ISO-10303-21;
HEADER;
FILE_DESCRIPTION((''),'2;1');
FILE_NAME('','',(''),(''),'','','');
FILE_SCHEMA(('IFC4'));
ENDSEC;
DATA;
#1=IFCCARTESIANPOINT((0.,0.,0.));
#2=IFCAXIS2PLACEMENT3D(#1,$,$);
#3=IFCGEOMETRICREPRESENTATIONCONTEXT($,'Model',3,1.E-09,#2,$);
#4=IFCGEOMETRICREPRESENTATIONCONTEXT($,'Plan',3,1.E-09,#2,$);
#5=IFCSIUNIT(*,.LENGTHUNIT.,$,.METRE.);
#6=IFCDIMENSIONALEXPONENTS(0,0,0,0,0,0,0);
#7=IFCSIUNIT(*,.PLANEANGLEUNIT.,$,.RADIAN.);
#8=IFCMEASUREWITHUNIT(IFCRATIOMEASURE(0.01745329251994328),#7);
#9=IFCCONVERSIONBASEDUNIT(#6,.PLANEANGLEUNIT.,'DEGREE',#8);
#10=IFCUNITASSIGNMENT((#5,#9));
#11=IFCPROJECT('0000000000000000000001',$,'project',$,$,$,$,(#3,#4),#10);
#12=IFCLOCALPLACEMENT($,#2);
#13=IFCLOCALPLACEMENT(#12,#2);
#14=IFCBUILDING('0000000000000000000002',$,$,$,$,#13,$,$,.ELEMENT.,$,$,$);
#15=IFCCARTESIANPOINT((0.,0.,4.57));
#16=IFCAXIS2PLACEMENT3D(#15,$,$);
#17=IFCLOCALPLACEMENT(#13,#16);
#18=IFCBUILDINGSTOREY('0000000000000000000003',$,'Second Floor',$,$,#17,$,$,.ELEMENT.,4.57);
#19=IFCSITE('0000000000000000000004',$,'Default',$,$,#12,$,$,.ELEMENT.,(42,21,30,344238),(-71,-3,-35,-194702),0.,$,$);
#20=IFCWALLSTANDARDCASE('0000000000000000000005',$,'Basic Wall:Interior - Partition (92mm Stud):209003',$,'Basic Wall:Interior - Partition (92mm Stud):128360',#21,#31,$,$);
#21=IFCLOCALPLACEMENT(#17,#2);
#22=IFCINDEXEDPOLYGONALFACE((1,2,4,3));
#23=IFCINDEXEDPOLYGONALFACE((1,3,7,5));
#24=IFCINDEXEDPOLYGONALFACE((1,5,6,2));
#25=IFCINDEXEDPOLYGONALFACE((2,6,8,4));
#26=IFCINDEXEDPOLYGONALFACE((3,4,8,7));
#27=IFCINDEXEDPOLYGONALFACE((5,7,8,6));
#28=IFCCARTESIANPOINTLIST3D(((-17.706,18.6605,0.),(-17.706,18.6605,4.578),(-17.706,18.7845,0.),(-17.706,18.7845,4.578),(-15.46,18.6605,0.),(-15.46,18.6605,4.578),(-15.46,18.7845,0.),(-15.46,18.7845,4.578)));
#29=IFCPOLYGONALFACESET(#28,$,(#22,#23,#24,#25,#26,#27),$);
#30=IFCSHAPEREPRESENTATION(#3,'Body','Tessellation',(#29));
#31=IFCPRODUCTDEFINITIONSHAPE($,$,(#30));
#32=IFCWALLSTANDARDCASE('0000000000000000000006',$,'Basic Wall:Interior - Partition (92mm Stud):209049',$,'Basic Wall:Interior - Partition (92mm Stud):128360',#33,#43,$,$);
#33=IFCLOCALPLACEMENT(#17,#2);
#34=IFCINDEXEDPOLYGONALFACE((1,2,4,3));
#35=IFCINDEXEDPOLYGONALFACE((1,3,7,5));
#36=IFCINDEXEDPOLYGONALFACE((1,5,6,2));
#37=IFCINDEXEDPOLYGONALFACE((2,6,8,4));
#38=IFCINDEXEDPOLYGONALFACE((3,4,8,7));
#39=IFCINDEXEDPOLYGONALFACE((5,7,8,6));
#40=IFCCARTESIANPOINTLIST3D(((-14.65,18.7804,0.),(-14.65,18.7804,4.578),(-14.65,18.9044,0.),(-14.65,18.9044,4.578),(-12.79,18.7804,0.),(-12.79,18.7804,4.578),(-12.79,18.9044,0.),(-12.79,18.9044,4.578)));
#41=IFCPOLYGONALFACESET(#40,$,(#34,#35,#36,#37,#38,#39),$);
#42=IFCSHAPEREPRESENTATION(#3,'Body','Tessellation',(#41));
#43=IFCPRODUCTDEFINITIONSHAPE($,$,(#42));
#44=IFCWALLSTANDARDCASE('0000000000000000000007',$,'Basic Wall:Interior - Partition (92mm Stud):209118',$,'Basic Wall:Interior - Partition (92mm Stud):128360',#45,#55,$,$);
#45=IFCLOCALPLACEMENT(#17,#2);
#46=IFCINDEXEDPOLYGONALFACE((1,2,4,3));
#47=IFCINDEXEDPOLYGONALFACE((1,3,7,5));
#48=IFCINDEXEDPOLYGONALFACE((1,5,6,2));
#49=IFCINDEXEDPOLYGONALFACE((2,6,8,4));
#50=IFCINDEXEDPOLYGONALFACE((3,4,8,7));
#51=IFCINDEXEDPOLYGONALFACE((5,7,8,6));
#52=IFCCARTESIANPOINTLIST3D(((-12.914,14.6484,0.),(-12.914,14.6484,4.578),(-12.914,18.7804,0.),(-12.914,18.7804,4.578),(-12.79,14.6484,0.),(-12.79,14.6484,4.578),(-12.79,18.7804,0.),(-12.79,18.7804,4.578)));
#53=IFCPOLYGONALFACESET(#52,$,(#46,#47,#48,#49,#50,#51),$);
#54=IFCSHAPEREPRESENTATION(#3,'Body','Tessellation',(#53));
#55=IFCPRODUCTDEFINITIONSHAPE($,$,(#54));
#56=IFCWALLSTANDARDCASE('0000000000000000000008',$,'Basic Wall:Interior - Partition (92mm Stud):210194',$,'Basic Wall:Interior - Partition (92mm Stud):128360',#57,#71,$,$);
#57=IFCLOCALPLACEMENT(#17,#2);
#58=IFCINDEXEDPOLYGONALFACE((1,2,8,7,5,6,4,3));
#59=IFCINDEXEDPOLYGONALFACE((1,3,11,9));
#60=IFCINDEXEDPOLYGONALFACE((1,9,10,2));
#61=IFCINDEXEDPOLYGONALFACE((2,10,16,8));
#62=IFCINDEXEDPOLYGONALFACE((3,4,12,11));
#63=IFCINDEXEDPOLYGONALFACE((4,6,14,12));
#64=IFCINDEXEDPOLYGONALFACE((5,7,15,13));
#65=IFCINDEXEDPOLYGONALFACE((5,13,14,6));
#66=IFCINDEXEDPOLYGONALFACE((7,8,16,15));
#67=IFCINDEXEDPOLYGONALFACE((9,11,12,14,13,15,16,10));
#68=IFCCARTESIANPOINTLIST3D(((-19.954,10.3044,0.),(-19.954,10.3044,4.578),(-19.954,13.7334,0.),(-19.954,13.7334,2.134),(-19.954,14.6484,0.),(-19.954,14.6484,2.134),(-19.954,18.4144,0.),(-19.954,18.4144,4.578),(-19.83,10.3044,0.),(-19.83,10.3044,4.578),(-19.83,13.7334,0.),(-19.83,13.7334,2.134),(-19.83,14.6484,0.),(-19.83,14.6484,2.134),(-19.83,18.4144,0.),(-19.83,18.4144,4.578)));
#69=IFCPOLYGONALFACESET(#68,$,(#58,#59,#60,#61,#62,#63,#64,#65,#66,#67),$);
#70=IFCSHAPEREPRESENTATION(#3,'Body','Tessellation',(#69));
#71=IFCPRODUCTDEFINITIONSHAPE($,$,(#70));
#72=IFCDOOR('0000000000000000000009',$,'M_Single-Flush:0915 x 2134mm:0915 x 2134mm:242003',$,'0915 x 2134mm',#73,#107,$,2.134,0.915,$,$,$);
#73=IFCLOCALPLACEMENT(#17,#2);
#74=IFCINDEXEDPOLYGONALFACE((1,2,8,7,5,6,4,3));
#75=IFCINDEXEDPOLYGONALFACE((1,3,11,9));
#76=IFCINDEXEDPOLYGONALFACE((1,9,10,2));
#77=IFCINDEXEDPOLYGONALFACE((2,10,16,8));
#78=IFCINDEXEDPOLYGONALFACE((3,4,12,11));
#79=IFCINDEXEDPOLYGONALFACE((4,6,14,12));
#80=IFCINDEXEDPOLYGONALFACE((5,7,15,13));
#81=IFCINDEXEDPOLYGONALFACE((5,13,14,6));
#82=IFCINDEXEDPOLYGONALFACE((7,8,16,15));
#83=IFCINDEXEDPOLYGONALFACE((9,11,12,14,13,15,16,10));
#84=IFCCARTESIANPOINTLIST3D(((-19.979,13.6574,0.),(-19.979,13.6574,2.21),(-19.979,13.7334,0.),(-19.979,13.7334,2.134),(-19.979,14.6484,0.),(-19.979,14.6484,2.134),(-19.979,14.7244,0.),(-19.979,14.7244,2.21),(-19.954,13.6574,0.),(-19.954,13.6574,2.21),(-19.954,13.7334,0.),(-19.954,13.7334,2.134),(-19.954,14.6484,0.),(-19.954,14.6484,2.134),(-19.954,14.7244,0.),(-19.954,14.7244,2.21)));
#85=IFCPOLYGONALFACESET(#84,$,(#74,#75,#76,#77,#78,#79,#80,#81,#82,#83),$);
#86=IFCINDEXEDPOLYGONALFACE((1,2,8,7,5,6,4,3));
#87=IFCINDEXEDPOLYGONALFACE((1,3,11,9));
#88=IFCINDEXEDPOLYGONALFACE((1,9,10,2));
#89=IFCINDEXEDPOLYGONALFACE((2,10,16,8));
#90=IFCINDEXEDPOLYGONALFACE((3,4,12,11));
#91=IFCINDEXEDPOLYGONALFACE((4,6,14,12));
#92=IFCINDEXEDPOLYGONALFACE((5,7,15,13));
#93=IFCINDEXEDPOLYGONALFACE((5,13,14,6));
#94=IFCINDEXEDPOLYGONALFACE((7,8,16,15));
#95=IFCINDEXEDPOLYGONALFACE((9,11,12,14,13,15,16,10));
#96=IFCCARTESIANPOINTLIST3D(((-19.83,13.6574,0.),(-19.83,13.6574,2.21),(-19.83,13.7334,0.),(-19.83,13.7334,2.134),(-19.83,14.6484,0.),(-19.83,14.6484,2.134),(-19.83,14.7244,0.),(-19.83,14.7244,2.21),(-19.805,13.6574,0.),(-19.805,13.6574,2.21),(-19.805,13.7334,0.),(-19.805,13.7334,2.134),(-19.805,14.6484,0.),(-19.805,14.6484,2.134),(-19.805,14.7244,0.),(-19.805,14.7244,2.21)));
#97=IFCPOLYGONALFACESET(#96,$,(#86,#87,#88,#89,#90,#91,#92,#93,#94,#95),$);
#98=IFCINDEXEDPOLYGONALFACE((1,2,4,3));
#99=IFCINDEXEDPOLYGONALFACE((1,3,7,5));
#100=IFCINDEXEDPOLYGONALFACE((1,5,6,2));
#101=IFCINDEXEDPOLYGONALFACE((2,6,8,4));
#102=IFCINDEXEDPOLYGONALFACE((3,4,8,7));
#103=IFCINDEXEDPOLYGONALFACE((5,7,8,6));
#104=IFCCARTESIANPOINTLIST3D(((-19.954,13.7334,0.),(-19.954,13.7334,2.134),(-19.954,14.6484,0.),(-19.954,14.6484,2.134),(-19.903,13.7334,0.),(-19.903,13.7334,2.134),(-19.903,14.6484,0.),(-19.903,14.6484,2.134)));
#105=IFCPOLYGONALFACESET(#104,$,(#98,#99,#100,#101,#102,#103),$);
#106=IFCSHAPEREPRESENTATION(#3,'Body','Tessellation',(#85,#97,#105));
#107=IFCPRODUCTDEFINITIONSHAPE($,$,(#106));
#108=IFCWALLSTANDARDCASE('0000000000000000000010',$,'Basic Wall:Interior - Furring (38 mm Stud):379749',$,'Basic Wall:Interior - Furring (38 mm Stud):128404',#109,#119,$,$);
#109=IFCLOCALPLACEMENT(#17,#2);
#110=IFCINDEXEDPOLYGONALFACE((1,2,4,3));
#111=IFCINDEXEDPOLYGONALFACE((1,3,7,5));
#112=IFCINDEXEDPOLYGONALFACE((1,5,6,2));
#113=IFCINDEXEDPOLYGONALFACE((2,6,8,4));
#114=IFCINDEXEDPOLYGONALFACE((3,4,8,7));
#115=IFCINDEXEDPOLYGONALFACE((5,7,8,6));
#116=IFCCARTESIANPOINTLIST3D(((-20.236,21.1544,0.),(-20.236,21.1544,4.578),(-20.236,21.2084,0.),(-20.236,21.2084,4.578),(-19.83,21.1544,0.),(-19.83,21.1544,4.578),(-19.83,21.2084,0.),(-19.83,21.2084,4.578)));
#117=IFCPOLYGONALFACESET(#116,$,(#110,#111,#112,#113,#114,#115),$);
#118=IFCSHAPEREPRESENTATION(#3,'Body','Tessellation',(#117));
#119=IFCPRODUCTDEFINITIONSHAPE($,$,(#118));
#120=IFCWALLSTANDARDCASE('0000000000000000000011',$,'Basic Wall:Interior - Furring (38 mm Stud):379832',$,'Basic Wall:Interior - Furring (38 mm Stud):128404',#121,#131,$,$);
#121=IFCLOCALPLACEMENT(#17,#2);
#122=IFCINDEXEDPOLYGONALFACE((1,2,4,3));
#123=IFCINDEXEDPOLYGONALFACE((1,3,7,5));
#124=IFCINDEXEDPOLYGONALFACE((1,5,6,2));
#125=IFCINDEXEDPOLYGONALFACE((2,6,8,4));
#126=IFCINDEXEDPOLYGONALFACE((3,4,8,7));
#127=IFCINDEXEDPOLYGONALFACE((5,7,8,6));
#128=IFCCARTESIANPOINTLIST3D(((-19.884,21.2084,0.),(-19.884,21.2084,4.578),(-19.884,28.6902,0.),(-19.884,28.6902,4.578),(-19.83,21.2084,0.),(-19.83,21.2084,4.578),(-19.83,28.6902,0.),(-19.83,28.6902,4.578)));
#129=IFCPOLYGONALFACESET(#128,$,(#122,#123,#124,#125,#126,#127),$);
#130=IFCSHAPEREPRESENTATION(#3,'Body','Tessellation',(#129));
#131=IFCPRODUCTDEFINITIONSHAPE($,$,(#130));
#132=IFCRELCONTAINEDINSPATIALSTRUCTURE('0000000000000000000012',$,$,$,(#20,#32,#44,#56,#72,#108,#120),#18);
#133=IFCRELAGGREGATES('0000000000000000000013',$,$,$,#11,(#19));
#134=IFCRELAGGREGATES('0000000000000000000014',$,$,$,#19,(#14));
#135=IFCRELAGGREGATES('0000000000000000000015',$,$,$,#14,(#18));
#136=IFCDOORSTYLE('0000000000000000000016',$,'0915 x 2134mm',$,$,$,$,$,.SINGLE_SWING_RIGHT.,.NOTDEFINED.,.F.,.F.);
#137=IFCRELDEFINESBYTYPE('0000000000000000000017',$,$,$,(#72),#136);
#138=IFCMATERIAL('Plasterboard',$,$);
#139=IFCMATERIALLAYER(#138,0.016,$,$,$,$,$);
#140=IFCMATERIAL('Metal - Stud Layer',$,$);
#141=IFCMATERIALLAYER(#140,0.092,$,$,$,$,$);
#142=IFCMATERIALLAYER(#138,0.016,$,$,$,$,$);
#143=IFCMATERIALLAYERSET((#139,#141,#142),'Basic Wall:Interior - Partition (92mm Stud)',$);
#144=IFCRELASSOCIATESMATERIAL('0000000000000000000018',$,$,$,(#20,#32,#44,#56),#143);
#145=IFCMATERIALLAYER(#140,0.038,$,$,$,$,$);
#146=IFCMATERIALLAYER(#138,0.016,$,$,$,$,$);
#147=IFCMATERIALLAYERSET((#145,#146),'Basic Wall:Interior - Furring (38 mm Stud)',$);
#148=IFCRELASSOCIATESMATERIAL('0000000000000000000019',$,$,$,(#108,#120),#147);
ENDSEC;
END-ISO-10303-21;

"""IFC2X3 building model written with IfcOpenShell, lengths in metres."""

from ifc_helpers import new_model, entity, si_unit, converted_unit, frame, frame_2d, origin, origin_2d_with_axis, place, context, project, spatial, polyline, rectangle, outline, extrude, source, transform, mapped, material, layer, layer_set, layer_usage, type_object, type_shapes, element, fill, save


model = new_model("IFC2X3")

# Units and contexts
model_context = context("Model", 3, precision=1e-09, world=origin())
plan_context = context("Plan", 3, precision=1e-09, world=origin())
ifc_project = project(units=[si_unit("LENGTHUNIT", "METRE"), converted_unit("PLANEANGLEUNIT", "DEGREE", entity("IfcRatioMeasure", 0.01745329251994328), si_unit("PLANEANGLEUNIT", "RADIAN"), dimensions=[0, 0, 0, 0, 0, 0, 0])], contexts=[model_context, plan_context])

# Site, building, storey
site_placement = place(None, origin())
site = spatial("IfcSite", under=ifc_project, at=site_placement, Name="Default", CompositionType="ELEMENT", RefLatitude=(42, 21, 30, 344238), RefLongitude=(-71, -3, -35, -194702), RefElevation=0.0)
building_placement = place(site_placement, origin())
building = spatial("IfcBuilding", under=site, at=building_placement, CompositionType="ELEMENT")
storey_placement = place(building_placement, frame((0.0, 0.0, 4.57)))
storey = spatial("IfcBuildingStorey", under=building, at=storey_placement, Name="Second Floor", CompositionType="ELEMENT", Elevation=4.57)

# Shared definitions
ifc_material_1 = material(Name="Plasterboard")
ifc_layer_1 = layer(ifc_material_1, 0.016)
ifc_material_2 = material(Name="Metal - Stud Layer")
ifc_layer_2 = layer(ifc_material_2, 0.092)
ifc_layer_3 = layer(ifc_material_1, 0.016)
ifc_layer_set_1 = layer_set([ifc_layer_1, ifc_layer_2, ifc_layer_3], Name="Basic Wall:Interior - Partition (92mm Stud)")
door_style_1 = type_object("IfcDoorStyle", Name="0915 x 2134mm", ConstructionType="NOTDEFINED", OperationType="SINGLE_SWING_RIGHT", ParameterTakesPrecedence=False, Sizeable=False)
shared_shape_1 = source(origin(), model_context, "Body", "SweptSolid", [
    extrude(outline(polyline([(-0.5335, -1.124), (0.5335, -1.124), (0.5335, 1.086), (0.4575, 1.086), (0.4575, -1.048), (-0.4575, -1.048), (-0.4575, 1.086), (-0.5335, 1.086), (-0.5335, -1.124)])), frame((0.4575, 0.124, 1.086), z_axis=(0.0, 1.0, 0.0), x_axis=(1.0, 0.0, 0.0)), (0.0, 0.0, 1.0), 0.025),
    extrude(outline(polyline([(-1.124, -0.5335), (1.086, -0.5335), (1.086, -0.4575), (-1.048, -0.4575), (-1.048, 0.4575), (1.086, 0.4575), (1.086, 0.5335), (-1.124, 0.5335), (-1.124, -0.5335)])), frame((0.4575, -0.025, 1.086), z_axis=(0.0, 1.0, 0.0), x_axis=(0.0, 0.0, -1.0)), (0.0, 0.0, 1.0), 0.025),
    extrude(rectangle(XDim=0.051, YDim=0.915, at=origin_2d_with_axis()), frame((0.4575, 0.0985, 0.0), z_axis=(0.0, 0.0, 1.0), x_axis=(0.0, 1.0, 0.0)), (0.0, 0.0, 1.0), 2.134),
])
type_shapes(door_style_1, [shared_shape_1])

# Walls
ifc_layer_usage_1 = layer_usage(ifc_layer_set_1, "AXIS2", "NEGATIVE", 0.062)
wall_1_placement = place(storey_placement, frame((-17.706, 18.7225, 0.0)))
element("IfcWallStandardCase", 1, at=wall_1_placement, inside=storey, material=ifc_layer_usage_1, Name="Basic Wall:Interior - Partition (92mm Stud):209003", ObjectType="Basic Wall:Interior - Partition (92mm Stud):128360", context=model_context, shape_type="SweptSolid", body=[
    extrude(rectangle(XDim=2.246, YDim=0.124, at=frame_2d((1.123, 0.0), x_axis=(-1.0, 0.0))), origin(), (0.0, 0.0, 1.0), 4.578),
])
ifc_layer_usage_2 = layer_usage(ifc_layer_set_1, "AXIS2", "NEGATIVE", 0.062)
wall_2_placement = place(storey_placement, frame((-14.65, 18.8424, 0.0)))
element("IfcWallStandardCase", 2, at=wall_2_placement, inside=storey, material=ifc_layer_usage_2, Name="Basic Wall:Interior - Partition (92mm Stud):209049", ObjectType="Basic Wall:Interior - Partition (92mm Stud):128360", context=model_context, shape_type="SweptSolid", body=[
    extrude(rectangle(XDim=1.86, YDim=0.124, at=frame_2d((0.93, 0.0), x_axis=(-1.0, 0.0))), origin(), (0.0, 0.0, 1.0), 4.578),
])
ifc_layer_usage_3 = layer_usage(ifc_layer_set_1, "AXIS2", "NEGATIVE", 0.062)
wall_3_placement = place(storey_placement, frame((-12.852, 18.7804, 0.0), z_axis=(0.0, 0.0, 1.0), x_axis=(0.0, -1.0, 0.0)))
element("IfcWallStandardCase", 3, at=wall_3_placement, inside=storey, material=ifc_layer_usage_3, Name="Basic Wall:Interior - Partition (92mm Stud):209118", ObjectType="Basic Wall:Interior - Partition (92mm Stud):128360", context=model_context, shape_type="SweptSolid", body=[
    extrude(rectangle(XDim=4.132, YDim=0.124, at=frame_2d((2.066, 0.0), x_axis=(-1.0, 0.0))), origin(), (0.0, 0.0, 1.0), 4.578),
])

# Wall, opening, door
ifc_layer_usage_4 = layer_usage(ifc_layer_set_1, "AXIS2", "NEGATIVE", 0.062)
wall_4_placement = place(storey_placement, frame((-19.892, 18.4144, 0.0), z_axis=(0.0, 0.0, 1.0), x_axis=(0.0, -1.0, 0.0)))
wall_4 = element("IfcWallStandardCase", 4, at=wall_4_placement, inside=storey, material=ifc_layer_usage_4, Name="Basic Wall:Interior - Partition (92mm Stud):210194", ObjectType="Basic Wall:Interior - Partition (92mm Stud):128360", context=model_context, shape_type="SweptSolid", body=[
    extrude(rectangle(XDim=8.11, YDim=0.124, at=frame_2d((4.055, 0.0), x_axis=(-1.0, 0.0))), origin(), (0.0, 0.0, 1.0), 4.578),
])
opening_1_placement = place(wall_4_placement, frame((4.681, 0.062, 0.0)))
opening_1 = element("IfcOpeningElement", 5, at=opening_1_placement, cuts=wall_4, ObjectType="Opening", context=model_context, shape_type="SweptSolid", body=[
    extrude(rectangle(XDim=0.915, YDim=2.134, at=frame_2d((1.067, 0.4575), x_axis=(0.0, 1.0))), frame((0.0, 0.0, 0.0), z_axis=(0.0, -1.0, 0.0), x_axis=(0.0, 0.0, 1.0)), (0.0, 0.0, 1.0), 0.124),
])
door_1_placement = place(opening_1_placement, frame((0.0, 0.0, 0.0), z_axis=(0.0, 0.0, 1.0), x_axis=(-1.0, 0.0, 0.0)))
door_1 = element("IfcDoor", 6, at=door_1_placement, inside=storey, type_object=door_style_1, Name="M_Single-Flush:0915 x 2134mm:0915 x 2134mm:242003", ObjectType="0915 x 2134mm", OverallHeight=2.134, OverallWidth=0.915, context=model_context, shape_type="MappedRepresentation", body=[
    mapped(shared_shape_1, transform((0.0, 0.0, 0.0), scale=1.0)),
])
fill(opening_1, door_1)

# Walls
ifc_layer_4 = layer(ifc_material_2, 0.038)
ifc_layer_5 = layer(ifc_material_1, 0.016)
ifc_layer_set_2 = layer_set([ifc_layer_4, ifc_layer_5], Name="Basic Wall:Interior - Furring (38 mm Stud)")
ifc_layer_usage_5 = layer_usage(ifc_layer_set_2, "AXIS2", "NEGATIVE", 0.027)
wall_5_placement = place(storey_placement, frame((-20.236, 21.1814, 0.0)))
element("IfcWallStandardCase", 7, at=wall_5_placement, inside=storey, material=ifc_layer_usage_5, Name="Basic Wall:Interior - Furring (38 mm Stud):379749", ObjectType="Basic Wall:Interior - Furring (38 mm Stud):128404", context=model_context, shape_type="SweptSolid", body=[
    extrude(rectangle(XDim=0.406, YDim=0.054, at=frame_2d((0.203, 0.0), x_axis=(-1.0, 0.0))), origin(), (0.0, 0.0, 1.0), 4.578),
])
ifc_layer_usage_6 = layer_usage(ifc_layer_set_2, "AXIS2", "NEGATIVE", 0.027)
wall_6_placement = place(storey_placement, frame((-19.857, 21.2084, 0.0), z_axis=(0.0, 0.0, 1.0), x_axis=(0.0, 1.0, 0.0)))
element("IfcWallStandardCase", 8, at=wall_6_placement, inside=storey, material=ifc_layer_usage_6, Name="Basic Wall:Interior - Furring (38 mm Stud):379832", ObjectType="Basic Wall:Interior - Furring (38 mm Stud):128404", context=model_context, shape_type="SweptSolid", body=[
    extrude(rectangle(XDim=7.4818, YDim=0.054, at=frame_2d((3.7409, 0.0), x_axis=(-1.0, 0.0))), origin(), (0.0, 0.0, 1.0), 4.578),
])

save(model, "model.ifc")
